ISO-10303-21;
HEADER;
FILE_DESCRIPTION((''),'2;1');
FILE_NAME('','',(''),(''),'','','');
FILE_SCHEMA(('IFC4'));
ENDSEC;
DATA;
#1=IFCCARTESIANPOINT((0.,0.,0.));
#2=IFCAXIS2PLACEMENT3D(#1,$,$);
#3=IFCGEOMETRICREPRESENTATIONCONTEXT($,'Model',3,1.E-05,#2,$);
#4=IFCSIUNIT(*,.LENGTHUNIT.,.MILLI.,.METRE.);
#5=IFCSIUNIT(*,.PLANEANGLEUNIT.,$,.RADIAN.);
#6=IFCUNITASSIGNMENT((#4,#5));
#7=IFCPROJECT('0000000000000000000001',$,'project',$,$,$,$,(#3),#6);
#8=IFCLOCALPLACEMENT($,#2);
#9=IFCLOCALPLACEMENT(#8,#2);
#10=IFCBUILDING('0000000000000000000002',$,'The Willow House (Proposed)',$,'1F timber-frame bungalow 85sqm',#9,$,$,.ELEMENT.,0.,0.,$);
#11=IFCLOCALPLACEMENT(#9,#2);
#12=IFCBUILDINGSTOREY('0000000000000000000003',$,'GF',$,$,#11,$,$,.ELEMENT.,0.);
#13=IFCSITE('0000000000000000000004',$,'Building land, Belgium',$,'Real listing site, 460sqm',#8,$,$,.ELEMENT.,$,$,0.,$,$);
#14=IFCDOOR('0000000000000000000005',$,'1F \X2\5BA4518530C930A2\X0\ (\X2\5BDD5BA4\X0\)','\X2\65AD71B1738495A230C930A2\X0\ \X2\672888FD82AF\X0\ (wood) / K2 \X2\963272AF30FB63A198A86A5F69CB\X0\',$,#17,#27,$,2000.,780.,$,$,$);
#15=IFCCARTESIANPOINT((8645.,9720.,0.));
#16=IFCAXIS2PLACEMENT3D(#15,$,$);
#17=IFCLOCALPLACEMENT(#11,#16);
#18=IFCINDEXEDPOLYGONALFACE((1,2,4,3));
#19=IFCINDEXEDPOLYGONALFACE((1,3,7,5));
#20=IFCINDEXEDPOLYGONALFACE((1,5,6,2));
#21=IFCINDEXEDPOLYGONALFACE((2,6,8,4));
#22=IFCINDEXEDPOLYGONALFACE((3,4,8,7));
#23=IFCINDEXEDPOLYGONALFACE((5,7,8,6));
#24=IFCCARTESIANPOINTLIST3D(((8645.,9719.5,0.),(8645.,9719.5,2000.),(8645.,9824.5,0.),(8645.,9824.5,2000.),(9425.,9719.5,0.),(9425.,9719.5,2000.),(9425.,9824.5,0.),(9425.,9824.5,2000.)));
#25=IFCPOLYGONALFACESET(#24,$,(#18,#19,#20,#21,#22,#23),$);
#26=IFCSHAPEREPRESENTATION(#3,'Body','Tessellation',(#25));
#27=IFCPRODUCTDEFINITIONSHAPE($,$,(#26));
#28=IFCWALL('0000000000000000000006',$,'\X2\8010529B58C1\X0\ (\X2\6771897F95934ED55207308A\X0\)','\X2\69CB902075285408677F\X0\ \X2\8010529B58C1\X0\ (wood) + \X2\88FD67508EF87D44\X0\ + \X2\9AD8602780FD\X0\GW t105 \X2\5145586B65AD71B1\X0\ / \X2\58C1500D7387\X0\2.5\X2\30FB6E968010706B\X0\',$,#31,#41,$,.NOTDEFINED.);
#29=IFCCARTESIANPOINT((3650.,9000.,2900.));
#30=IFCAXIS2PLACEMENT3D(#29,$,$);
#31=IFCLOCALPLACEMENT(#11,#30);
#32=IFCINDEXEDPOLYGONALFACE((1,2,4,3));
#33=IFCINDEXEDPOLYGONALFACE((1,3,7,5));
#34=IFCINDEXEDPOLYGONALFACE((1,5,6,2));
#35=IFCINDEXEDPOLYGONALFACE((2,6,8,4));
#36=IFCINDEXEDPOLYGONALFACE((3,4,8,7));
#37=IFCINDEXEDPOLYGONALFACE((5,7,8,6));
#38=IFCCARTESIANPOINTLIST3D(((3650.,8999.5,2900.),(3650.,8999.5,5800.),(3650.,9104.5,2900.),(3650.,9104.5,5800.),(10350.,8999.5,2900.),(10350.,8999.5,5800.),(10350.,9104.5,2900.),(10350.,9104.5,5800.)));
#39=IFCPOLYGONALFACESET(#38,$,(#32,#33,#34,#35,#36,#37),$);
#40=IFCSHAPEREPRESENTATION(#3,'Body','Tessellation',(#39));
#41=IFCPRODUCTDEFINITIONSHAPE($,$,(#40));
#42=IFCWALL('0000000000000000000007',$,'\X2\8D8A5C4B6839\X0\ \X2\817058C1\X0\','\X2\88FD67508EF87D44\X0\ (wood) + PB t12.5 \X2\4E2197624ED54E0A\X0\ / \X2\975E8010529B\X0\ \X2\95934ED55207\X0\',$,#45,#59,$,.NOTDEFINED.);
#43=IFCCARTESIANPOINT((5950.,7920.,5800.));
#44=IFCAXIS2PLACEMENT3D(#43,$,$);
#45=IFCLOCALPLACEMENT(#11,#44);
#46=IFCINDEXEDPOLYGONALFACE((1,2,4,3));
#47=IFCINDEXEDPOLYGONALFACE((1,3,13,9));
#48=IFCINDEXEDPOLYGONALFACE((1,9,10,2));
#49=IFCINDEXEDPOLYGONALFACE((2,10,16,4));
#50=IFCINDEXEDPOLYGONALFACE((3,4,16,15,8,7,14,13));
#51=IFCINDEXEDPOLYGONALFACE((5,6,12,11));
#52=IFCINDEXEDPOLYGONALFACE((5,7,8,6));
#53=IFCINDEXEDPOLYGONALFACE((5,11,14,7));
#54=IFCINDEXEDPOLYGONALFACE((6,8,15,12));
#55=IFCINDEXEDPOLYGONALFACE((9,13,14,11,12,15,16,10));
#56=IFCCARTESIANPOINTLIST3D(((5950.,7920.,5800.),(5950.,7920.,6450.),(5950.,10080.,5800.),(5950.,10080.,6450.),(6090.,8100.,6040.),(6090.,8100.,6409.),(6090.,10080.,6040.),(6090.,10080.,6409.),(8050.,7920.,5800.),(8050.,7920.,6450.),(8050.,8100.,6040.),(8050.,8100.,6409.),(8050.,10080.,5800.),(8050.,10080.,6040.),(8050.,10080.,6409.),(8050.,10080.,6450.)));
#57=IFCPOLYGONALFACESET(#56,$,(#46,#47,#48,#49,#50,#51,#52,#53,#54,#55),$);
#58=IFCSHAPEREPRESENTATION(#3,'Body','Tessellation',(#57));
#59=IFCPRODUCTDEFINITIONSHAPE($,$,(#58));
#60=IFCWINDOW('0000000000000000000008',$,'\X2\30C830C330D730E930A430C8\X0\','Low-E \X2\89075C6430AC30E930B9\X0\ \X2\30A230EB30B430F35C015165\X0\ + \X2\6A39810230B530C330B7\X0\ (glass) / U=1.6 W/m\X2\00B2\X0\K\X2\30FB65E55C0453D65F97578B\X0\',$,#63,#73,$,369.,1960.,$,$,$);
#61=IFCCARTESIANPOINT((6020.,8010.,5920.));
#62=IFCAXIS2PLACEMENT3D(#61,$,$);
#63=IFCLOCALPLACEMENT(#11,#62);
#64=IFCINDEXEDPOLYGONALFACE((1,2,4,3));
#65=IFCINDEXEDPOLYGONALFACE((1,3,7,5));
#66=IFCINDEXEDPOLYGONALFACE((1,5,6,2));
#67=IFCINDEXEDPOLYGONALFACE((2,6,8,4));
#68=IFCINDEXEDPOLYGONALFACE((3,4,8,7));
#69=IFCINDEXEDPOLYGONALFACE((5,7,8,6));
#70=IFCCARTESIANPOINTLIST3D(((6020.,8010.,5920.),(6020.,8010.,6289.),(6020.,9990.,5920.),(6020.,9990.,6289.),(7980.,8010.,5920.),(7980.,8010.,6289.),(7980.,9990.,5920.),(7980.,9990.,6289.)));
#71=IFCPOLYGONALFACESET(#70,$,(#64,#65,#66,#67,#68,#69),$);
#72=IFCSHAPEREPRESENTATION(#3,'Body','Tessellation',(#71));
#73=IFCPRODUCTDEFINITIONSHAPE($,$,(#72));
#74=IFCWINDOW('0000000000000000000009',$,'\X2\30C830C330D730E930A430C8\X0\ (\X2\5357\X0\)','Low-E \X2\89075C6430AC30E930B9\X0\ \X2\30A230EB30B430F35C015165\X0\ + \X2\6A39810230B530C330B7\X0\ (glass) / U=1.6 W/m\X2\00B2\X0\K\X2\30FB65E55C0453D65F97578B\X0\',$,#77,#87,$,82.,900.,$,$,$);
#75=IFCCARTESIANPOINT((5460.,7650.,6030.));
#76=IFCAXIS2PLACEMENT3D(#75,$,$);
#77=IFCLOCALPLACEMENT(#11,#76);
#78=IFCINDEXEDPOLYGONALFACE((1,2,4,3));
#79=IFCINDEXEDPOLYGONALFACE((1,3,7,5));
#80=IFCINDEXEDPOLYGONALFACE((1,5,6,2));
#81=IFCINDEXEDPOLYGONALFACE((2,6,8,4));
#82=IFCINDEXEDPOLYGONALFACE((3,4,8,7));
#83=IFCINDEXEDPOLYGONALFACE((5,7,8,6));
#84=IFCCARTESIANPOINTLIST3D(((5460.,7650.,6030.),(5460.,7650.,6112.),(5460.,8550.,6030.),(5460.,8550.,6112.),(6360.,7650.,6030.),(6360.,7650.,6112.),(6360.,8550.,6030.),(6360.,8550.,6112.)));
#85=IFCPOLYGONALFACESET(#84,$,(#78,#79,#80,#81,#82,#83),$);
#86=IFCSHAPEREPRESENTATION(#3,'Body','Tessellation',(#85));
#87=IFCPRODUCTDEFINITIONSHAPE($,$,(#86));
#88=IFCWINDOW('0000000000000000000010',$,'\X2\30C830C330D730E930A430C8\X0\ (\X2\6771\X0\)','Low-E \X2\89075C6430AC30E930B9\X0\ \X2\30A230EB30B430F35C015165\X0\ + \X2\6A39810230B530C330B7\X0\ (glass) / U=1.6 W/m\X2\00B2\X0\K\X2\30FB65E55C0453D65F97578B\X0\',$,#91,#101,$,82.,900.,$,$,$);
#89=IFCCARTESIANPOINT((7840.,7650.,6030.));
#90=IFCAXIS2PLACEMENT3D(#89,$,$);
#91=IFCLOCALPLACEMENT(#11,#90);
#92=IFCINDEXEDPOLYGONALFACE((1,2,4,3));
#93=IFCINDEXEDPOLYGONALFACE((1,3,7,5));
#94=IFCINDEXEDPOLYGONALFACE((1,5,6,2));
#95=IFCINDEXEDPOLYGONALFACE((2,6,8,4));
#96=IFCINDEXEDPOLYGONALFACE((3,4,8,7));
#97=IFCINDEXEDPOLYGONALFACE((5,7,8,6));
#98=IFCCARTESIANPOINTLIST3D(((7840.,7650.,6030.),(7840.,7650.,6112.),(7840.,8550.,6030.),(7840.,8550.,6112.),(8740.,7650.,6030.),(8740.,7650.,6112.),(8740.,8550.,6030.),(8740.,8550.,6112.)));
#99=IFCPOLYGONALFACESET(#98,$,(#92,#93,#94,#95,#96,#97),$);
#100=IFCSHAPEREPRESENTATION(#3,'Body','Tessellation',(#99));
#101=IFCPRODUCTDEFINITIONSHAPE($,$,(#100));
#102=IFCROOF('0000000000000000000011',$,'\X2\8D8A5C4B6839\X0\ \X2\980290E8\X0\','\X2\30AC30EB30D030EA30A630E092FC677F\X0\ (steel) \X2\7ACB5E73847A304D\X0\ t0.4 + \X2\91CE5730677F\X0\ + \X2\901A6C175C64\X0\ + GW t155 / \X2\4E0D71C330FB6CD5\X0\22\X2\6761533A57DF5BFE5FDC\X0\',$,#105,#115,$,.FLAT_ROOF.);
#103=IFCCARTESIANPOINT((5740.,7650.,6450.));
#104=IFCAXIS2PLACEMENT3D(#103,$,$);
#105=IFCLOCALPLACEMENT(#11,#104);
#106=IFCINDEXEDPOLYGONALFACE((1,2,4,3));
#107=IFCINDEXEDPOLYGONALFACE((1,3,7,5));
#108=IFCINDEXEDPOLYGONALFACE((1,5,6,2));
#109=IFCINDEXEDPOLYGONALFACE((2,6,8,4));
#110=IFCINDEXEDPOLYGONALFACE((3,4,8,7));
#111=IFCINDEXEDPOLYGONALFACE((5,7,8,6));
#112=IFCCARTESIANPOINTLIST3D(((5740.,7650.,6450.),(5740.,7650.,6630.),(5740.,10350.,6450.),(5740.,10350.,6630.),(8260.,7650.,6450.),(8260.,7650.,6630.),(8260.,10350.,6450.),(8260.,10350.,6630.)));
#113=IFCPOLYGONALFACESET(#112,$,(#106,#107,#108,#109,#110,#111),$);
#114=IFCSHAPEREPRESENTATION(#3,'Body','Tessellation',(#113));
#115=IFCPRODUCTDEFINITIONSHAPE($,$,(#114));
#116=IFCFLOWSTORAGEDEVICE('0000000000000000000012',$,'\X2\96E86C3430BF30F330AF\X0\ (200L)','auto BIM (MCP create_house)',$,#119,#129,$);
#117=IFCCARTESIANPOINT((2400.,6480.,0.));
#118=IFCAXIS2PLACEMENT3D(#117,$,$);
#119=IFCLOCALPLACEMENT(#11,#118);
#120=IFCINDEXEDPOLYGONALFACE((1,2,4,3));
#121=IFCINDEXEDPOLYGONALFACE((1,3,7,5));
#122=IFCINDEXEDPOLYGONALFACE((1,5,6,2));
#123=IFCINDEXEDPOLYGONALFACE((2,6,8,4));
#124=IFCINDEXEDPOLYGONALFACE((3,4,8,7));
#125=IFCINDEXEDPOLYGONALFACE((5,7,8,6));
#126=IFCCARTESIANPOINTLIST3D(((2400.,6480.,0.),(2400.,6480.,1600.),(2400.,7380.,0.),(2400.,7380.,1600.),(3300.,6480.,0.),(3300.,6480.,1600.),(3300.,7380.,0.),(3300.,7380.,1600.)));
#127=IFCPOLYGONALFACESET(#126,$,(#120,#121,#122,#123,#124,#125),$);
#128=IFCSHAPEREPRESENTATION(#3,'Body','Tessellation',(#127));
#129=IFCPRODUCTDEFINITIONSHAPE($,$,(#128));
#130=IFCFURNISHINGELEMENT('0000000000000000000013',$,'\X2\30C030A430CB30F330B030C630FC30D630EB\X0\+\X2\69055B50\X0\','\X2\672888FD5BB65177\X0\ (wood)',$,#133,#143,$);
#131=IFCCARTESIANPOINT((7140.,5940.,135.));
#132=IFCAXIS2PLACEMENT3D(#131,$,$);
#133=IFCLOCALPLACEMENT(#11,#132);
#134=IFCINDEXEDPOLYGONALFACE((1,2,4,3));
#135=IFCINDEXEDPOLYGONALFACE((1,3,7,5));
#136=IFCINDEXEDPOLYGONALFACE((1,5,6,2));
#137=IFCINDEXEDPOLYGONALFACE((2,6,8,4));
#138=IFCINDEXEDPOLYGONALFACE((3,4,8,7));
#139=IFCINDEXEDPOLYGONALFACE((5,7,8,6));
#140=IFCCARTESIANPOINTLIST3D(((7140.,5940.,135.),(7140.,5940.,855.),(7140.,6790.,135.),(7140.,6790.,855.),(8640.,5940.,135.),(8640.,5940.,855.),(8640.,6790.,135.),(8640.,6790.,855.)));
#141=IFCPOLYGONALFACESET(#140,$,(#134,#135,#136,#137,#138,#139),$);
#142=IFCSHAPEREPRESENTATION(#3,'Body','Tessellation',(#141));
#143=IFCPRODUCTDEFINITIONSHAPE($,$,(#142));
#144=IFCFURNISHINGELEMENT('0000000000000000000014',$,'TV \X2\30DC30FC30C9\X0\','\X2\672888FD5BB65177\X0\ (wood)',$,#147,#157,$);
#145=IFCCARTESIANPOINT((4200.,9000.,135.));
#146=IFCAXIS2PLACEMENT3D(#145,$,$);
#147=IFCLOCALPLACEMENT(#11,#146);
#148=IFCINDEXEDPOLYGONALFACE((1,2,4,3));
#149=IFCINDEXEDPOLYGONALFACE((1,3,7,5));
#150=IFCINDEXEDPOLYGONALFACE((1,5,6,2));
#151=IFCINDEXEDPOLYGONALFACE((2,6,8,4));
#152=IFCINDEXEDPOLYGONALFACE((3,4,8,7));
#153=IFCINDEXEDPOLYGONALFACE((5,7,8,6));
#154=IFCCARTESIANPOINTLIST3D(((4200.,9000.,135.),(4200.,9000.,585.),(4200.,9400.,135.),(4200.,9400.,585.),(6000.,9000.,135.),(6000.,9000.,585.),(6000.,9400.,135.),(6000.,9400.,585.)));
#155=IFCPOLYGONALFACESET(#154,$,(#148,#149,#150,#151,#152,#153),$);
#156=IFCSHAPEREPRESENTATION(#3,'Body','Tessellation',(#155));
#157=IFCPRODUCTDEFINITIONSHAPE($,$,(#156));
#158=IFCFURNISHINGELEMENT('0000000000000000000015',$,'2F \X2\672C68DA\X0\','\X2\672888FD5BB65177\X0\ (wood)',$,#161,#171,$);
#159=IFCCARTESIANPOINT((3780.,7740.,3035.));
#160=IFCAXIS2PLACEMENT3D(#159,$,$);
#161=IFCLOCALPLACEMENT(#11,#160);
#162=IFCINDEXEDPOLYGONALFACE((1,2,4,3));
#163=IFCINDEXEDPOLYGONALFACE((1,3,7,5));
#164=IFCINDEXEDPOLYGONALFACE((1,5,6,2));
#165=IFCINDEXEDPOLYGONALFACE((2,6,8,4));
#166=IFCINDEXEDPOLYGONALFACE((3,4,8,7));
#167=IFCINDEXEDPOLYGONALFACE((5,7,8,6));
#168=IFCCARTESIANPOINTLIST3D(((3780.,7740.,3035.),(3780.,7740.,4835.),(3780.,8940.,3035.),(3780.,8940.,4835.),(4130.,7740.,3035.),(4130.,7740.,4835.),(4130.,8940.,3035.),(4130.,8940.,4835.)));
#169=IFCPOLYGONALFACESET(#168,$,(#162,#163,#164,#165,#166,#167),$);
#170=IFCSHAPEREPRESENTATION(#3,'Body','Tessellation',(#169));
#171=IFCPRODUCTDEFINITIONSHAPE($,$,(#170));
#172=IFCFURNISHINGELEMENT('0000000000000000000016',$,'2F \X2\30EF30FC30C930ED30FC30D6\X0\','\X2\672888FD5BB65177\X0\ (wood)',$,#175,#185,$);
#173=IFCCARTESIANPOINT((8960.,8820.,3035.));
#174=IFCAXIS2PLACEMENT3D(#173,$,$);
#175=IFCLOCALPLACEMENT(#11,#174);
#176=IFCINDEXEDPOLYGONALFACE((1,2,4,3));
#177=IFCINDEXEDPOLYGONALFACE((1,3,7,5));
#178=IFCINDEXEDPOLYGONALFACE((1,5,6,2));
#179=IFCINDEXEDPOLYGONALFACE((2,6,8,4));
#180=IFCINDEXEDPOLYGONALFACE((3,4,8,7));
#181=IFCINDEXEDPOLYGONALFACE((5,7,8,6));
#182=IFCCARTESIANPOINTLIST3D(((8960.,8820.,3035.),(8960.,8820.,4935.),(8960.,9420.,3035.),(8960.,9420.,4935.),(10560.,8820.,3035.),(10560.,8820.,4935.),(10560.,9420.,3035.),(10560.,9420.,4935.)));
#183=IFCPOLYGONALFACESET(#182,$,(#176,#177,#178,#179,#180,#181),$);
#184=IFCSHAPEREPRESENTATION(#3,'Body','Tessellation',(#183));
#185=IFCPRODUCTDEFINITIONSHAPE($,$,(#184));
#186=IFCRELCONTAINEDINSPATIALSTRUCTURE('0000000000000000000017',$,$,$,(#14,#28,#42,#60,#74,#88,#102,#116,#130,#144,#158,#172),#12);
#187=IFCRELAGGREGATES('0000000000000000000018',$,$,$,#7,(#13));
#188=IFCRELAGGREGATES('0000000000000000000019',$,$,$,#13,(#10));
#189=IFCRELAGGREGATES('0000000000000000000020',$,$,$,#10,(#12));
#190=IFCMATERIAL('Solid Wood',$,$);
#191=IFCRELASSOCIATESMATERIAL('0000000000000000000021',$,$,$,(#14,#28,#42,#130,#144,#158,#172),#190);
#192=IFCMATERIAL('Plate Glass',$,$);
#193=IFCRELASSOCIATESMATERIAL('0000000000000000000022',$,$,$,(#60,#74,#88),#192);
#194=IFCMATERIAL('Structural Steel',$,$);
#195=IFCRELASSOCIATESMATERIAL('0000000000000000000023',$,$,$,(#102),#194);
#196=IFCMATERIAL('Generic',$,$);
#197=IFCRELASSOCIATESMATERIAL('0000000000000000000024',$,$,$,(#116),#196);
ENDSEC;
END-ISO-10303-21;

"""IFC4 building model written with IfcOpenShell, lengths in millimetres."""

from ifc_helpers import new_model, si_unit, frame, frame_2d, origin, place, context, project, spatial, rectangle, extrude, material, element, fill, save


model = new_model("IFC4")

# Units and contexts
model_context = context("Model", 3, precision=1e-05, world=origin())
ifc_project = project(units=[si_unit("LENGTHUNIT", "METRE", prefix="MILLI"), si_unit("PLANEANGLEUNIT", "RADIAN")], contexts=[model_context])

# Site, building, storey
site_placement = place(None, origin())
site = spatial("IfcSite", under=ifc_project, at=site_placement, Name="Building land, Belgium", ObjectType="Real listing site, 460sqm", CompositionType="ELEMENT", RefElevation=0.0)
building_placement = place(site_placement, origin())
building = spatial("IfcBuilding", under=site, at=building_placement, Name="The Willow House (Proposed)", ObjectType="1F timber-frame bungalow 85sqm", CompositionType="ELEMENT", ElevationOfRefHeight=0.0, ElevationOfTerrain=0.0)
storey_placement = place(building_placement, origin())
storey = spatial("IfcBuildingStorey", under=building, at=storey_placement, Name="GF", CompositionType="ELEMENT", Elevation=0.0)

# Shared definitions
ifc_material_1 = material(Name="Solid Wood")

# Door
door_placement = place(storey_placement, frame((8645.0, 9720.0, 0.0)))
element("IfcDoor", 1, at=door_placement, inside=storey, material=ifc_material_1, Name="1F 室内ドア (寝室)", Description="断熱玄関ドア 木製芯 (wood) / K2 防犯・採風機構", OverallHeight=2000.0, OverallWidth=780.0, context=model_context, shape_type="SweptSolid", body=[
    extrude(rectangle(XDim=780.0, YDim=105.0, at=frame_2d((390.0, 52.0))), frame((8645.0, 9720.0, 0.0)), (0.0, 0.0, 1.0), 2000.0),
])

# Wall
wall_1_placement = place(storey_placement, frame((3650.0, 9000.0, 2900.0)))
element("IfcWall", 2, at=wall_1_placement, inside=storey, material=ifc_material_1, Name="耐力壁 (東西間仕切り)", Description="構造用合板 耐力壁 (wood) + 製材軸組 + 高性能GW t105 充填断熱 / 壁倍率2.5・準耐火", PredefinedType="NOTDEFINED", context=model_context, shape_type="SweptSolid", body=[
    extrude(rectangle(XDim=6700.0, YDim=105.0, at=frame_2d((3350.0, 52.0))), frame((3650.0, 9000.0, 2900.0)), (0.0, 0.0, 1.0), 2900.0),
])

# Wall, openings, windows
wall_2_placement = place(storey_placement, frame((5950.0, 7920.0, 5800.0)))
wall_2 = element("IfcWall", 3, at=wall_2_placement, inside=storey, material=ifc_material_1, Name="越屋根 腰壁", Description="製材軸組 (wood) + PB t12.5 両面仕上 / 非耐力 間仕切", PredefinedType="NOTDEFINED", context=model_context, shape_type="SweptSolid", body=[
    extrude(rectangle(XDim=2100.0, YDim=2160.0, at=frame_2d((1050.0, 1080.0))), frame((5950.0, 7920.0, 5800.0)), (0.0, 0.0, 1.0), 650.0),
])
opening_1_placement = place(storey_placement, frame((6020.0, 8010.0, 5920.0)))
opening_1 = element("IfcOpeningElement", 4, at=opening_1_placement, cuts=wall_2, PredefinedType="NOTDEFINED", context=model_context, shape_type="SweptSolid", body=[
    extrude(rectangle(XDim=1960.0, YDim=1980.0, at=frame_2d((980.0, 990.0))), frame((6020.0, 8010.0, 5920.0)), (0.0, 0.0, 1.0), 369.0),
])
opening_2_placement = place(storey_placement, frame((5460.0, 7650.0, 6030.0)))
opening_2 = element("IfcOpeningElement", 5, at=opening_2_placement, cuts=wall_2, PredefinedType="NOTDEFINED", context=model_context, shape_type="SweptSolid", body=[
    extrude(rectangle(XDim=900.0, YDim=900.0, at=frame_2d((450.0, 450.0))), frame((5460.0, 7650.0, 6030.0)), (0.0, 0.0, 1.0), 82.0),
])
opening_3_placement = place(storey_placement, frame((7840.0, 7650.0, 6030.0)))
opening_3 = element("IfcOpeningElement", 6, at=opening_3_placement, cuts=wall_2, PredefinedType="NOTDEFINED", context=model_context, shape_type="SweptSolid", body=[
    extrude(rectangle(XDim=900.0, YDim=900.0, at=frame_2d((450.0, 450.0))), frame((7840.0, 7650.0, 6030.0)), (0.0, 0.0, 1.0), 82.0),
])
ifc_material_2 = material(Name="Plate Glass")
window_1_placement = place(storey_placement, frame((6020.0, 8010.0, 5920.0)))
window_1 = element("IfcWindow", 7, at=window_1_placement, inside=storey, material=ifc_material_2, Name="トップライト", Description="Low-E 複層ガラス アルゴン封入 + 樹脂サッシ (glass) / U=1.6 W/m²K・日射取得型", OverallHeight=369.0, OverallWidth=1960.0, context=model_context, shape_type="SweptSolid", body=[
    extrude(rectangle(XDim=1960.0, YDim=1980.0, at=frame_2d((980.0, 990.0))), frame((6020.0, 8010.0, 5920.0)), (0.0, 0.0, 1.0), 369.0),
])
fill(opening_1, window_1)
window_2_placement = place(storey_placement, frame((5460.0, 7650.0, 6030.0)))
window_2 = element("IfcWindow", 8, at=window_2_placement, inside=storey, material=ifc_material_2, Name="トップライト (南)", Description="Low-E 複層ガラス アルゴン封入 + 樹脂サッシ (glass) / U=1.6 W/m²K・日射取得型", OverallHeight=82.0, OverallWidth=900.0, context=model_context, shape_type="SweptSolid", body=[
    extrude(rectangle(XDim=900.0, YDim=900.0, at=frame_2d((450.0, 450.0))), frame((5460.0, 7650.0, 6030.0)), (0.0, 0.0, 1.0), 82.0),
])
fill(opening_2, window_2)
window_3_placement = place(storey_placement, frame((7840.0, 7650.0, 6030.0)))
window_3 = element("IfcWindow", 9, at=window_3_placement, inside=storey, material=ifc_material_2, Name="トップライト (東)", Description="Low-E 複層ガラス アルゴン封入 + 樹脂サッシ (glass) / U=1.6 W/m²K・日射取得型", OverallHeight=82.0, OverallWidth=900.0, context=model_context, shape_type="SweptSolid", body=[
    extrude(rectangle(XDim=900.0, YDim=900.0, at=frame_2d((450.0, 450.0))), frame((7840.0, 7650.0, 6030.0)), (0.0, 0.0, 1.0), 82.0),
])
fill(opening_3, window_3)

# Roof
ifc_material_3 = material(Name="Structural Steel")
roof_placement = place(storey_placement, frame((5740.0, 7650.0, 6450.0)))
element("IfcRoof", 10, at=roof_placement, inside=storey, material=ifc_material_3, Name="越屋根 頂部", Description="ガルバリウム鋼板 (steel) 立平葺き t0.4 + 野地板 + 通気層 + GW t155 / 不燃・法22条区域対応", PredefinedType="FLAT_ROOF", context=model_context, shape_type="SweptSolid", body=[
    extrude(rectangle(XDim=2520.0, YDim=2700.0, at=frame_2d((1260.0, 1350.0))), frame((5740.0, 7650.0, 6450.0)), (0.0, 0.0, 1.0), 180.0),
])

# Flow storage device
ifc_material_4 = material(Name="Generic")
flow_storage_device_placement = place(storey_placement, frame((2400.0, 6480.0, 0.0)))
element("IfcFlowStorageDevice", 11, at=flow_storage_device_placement, inside=storey, material=ifc_material_4, Name="雨水タンク (200L)", Description="auto BIM (MCP create_house)", context=model_context, shape_type="SweptSolid", body=[
    extrude(rectangle(XDim=900.0, YDim=900.0, at=frame_2d((450.0, 450.0))), frame((2400.0, 6480.0, 0.0)), (0.0, 0.0, 1.0), 1600.0),
])

# Furnishing elements
furnishing_1_placement = place(storey_placement, frame((7140.0, 5940.0, 135.0)))
element("IfcFurnishingElement", 12, at=furnishing_1_placement, inside=storey, material=ifc_material_1, Name="ダイニングテーブル+椅子", Description="木製家具 (wood)", context=model_context, shape_type="SweptSolid", body=[
    extrude(rectangle(XDim=1500.0, YDim=850.0, at=frame_2d((750.0, 425.0))), frame((7140.0, 5940.0, 135.0)), (0.0, 0.0, 1.0), 720.0),
])
furnishing_2_placement = place(storey_placement, frame((4200.0, 9000.0, 135.0)))
element("IfcFurnishingElement", 13, at=furnishing_2_placement, inside=storey, material=ifc_material_1, Name="TV ボード", Description="木製家具 (wood)", context=model_context, shape_type="SweptSolid", body=[
    extrude(rectangle(XDim=1800.0, YDim=400.0, at=frame_2d((900.0, 200.0))), frame((4200.0, 9000.0, 135.0)), (0.0, 0.0, 1.0), 450.0),
])
furnishing_3_placement = place(storey_placement, frame((3780.0, 7740.0, 3035.0)))
element("IfcFurnishingElement", 14, at=furnishing_3_placement, inside=storey, material=ifc_material_1, Name="2F 本棚", Description="木製家具 (wood)", context=model_context, shape_type="SweptSolid", body=[
    extrude(rectangle(XDim=350.0, YDim=1200.0, at=frame_2d((175.0, 600.0))), frame((3780.0, 7740.0, 3035.0)), (0.0, 0.0, 1.0), 1800.0),
])
furnishing_4_placement = place(storey_placement, frame((8960.0, 8820.0, 3035.0)))
element("IfcFurnishingElement", 15, at=furnishing_4_placement, inside=storey, material=ifc_material_1, Name="2F ワードローブ", Description="木製家具 (wood)", context=model_context, shape_type="SweptSolid", body=[
    extrude(rectangle(XDim=1600.0, YDim=600.0, at=frame_2d((800.0, 300.0))), frame((8960.0, 8820.0, 3035.0)), (0.0, 0.0, 1.0), 1900.0),
])

save(model, "model.ifc")
